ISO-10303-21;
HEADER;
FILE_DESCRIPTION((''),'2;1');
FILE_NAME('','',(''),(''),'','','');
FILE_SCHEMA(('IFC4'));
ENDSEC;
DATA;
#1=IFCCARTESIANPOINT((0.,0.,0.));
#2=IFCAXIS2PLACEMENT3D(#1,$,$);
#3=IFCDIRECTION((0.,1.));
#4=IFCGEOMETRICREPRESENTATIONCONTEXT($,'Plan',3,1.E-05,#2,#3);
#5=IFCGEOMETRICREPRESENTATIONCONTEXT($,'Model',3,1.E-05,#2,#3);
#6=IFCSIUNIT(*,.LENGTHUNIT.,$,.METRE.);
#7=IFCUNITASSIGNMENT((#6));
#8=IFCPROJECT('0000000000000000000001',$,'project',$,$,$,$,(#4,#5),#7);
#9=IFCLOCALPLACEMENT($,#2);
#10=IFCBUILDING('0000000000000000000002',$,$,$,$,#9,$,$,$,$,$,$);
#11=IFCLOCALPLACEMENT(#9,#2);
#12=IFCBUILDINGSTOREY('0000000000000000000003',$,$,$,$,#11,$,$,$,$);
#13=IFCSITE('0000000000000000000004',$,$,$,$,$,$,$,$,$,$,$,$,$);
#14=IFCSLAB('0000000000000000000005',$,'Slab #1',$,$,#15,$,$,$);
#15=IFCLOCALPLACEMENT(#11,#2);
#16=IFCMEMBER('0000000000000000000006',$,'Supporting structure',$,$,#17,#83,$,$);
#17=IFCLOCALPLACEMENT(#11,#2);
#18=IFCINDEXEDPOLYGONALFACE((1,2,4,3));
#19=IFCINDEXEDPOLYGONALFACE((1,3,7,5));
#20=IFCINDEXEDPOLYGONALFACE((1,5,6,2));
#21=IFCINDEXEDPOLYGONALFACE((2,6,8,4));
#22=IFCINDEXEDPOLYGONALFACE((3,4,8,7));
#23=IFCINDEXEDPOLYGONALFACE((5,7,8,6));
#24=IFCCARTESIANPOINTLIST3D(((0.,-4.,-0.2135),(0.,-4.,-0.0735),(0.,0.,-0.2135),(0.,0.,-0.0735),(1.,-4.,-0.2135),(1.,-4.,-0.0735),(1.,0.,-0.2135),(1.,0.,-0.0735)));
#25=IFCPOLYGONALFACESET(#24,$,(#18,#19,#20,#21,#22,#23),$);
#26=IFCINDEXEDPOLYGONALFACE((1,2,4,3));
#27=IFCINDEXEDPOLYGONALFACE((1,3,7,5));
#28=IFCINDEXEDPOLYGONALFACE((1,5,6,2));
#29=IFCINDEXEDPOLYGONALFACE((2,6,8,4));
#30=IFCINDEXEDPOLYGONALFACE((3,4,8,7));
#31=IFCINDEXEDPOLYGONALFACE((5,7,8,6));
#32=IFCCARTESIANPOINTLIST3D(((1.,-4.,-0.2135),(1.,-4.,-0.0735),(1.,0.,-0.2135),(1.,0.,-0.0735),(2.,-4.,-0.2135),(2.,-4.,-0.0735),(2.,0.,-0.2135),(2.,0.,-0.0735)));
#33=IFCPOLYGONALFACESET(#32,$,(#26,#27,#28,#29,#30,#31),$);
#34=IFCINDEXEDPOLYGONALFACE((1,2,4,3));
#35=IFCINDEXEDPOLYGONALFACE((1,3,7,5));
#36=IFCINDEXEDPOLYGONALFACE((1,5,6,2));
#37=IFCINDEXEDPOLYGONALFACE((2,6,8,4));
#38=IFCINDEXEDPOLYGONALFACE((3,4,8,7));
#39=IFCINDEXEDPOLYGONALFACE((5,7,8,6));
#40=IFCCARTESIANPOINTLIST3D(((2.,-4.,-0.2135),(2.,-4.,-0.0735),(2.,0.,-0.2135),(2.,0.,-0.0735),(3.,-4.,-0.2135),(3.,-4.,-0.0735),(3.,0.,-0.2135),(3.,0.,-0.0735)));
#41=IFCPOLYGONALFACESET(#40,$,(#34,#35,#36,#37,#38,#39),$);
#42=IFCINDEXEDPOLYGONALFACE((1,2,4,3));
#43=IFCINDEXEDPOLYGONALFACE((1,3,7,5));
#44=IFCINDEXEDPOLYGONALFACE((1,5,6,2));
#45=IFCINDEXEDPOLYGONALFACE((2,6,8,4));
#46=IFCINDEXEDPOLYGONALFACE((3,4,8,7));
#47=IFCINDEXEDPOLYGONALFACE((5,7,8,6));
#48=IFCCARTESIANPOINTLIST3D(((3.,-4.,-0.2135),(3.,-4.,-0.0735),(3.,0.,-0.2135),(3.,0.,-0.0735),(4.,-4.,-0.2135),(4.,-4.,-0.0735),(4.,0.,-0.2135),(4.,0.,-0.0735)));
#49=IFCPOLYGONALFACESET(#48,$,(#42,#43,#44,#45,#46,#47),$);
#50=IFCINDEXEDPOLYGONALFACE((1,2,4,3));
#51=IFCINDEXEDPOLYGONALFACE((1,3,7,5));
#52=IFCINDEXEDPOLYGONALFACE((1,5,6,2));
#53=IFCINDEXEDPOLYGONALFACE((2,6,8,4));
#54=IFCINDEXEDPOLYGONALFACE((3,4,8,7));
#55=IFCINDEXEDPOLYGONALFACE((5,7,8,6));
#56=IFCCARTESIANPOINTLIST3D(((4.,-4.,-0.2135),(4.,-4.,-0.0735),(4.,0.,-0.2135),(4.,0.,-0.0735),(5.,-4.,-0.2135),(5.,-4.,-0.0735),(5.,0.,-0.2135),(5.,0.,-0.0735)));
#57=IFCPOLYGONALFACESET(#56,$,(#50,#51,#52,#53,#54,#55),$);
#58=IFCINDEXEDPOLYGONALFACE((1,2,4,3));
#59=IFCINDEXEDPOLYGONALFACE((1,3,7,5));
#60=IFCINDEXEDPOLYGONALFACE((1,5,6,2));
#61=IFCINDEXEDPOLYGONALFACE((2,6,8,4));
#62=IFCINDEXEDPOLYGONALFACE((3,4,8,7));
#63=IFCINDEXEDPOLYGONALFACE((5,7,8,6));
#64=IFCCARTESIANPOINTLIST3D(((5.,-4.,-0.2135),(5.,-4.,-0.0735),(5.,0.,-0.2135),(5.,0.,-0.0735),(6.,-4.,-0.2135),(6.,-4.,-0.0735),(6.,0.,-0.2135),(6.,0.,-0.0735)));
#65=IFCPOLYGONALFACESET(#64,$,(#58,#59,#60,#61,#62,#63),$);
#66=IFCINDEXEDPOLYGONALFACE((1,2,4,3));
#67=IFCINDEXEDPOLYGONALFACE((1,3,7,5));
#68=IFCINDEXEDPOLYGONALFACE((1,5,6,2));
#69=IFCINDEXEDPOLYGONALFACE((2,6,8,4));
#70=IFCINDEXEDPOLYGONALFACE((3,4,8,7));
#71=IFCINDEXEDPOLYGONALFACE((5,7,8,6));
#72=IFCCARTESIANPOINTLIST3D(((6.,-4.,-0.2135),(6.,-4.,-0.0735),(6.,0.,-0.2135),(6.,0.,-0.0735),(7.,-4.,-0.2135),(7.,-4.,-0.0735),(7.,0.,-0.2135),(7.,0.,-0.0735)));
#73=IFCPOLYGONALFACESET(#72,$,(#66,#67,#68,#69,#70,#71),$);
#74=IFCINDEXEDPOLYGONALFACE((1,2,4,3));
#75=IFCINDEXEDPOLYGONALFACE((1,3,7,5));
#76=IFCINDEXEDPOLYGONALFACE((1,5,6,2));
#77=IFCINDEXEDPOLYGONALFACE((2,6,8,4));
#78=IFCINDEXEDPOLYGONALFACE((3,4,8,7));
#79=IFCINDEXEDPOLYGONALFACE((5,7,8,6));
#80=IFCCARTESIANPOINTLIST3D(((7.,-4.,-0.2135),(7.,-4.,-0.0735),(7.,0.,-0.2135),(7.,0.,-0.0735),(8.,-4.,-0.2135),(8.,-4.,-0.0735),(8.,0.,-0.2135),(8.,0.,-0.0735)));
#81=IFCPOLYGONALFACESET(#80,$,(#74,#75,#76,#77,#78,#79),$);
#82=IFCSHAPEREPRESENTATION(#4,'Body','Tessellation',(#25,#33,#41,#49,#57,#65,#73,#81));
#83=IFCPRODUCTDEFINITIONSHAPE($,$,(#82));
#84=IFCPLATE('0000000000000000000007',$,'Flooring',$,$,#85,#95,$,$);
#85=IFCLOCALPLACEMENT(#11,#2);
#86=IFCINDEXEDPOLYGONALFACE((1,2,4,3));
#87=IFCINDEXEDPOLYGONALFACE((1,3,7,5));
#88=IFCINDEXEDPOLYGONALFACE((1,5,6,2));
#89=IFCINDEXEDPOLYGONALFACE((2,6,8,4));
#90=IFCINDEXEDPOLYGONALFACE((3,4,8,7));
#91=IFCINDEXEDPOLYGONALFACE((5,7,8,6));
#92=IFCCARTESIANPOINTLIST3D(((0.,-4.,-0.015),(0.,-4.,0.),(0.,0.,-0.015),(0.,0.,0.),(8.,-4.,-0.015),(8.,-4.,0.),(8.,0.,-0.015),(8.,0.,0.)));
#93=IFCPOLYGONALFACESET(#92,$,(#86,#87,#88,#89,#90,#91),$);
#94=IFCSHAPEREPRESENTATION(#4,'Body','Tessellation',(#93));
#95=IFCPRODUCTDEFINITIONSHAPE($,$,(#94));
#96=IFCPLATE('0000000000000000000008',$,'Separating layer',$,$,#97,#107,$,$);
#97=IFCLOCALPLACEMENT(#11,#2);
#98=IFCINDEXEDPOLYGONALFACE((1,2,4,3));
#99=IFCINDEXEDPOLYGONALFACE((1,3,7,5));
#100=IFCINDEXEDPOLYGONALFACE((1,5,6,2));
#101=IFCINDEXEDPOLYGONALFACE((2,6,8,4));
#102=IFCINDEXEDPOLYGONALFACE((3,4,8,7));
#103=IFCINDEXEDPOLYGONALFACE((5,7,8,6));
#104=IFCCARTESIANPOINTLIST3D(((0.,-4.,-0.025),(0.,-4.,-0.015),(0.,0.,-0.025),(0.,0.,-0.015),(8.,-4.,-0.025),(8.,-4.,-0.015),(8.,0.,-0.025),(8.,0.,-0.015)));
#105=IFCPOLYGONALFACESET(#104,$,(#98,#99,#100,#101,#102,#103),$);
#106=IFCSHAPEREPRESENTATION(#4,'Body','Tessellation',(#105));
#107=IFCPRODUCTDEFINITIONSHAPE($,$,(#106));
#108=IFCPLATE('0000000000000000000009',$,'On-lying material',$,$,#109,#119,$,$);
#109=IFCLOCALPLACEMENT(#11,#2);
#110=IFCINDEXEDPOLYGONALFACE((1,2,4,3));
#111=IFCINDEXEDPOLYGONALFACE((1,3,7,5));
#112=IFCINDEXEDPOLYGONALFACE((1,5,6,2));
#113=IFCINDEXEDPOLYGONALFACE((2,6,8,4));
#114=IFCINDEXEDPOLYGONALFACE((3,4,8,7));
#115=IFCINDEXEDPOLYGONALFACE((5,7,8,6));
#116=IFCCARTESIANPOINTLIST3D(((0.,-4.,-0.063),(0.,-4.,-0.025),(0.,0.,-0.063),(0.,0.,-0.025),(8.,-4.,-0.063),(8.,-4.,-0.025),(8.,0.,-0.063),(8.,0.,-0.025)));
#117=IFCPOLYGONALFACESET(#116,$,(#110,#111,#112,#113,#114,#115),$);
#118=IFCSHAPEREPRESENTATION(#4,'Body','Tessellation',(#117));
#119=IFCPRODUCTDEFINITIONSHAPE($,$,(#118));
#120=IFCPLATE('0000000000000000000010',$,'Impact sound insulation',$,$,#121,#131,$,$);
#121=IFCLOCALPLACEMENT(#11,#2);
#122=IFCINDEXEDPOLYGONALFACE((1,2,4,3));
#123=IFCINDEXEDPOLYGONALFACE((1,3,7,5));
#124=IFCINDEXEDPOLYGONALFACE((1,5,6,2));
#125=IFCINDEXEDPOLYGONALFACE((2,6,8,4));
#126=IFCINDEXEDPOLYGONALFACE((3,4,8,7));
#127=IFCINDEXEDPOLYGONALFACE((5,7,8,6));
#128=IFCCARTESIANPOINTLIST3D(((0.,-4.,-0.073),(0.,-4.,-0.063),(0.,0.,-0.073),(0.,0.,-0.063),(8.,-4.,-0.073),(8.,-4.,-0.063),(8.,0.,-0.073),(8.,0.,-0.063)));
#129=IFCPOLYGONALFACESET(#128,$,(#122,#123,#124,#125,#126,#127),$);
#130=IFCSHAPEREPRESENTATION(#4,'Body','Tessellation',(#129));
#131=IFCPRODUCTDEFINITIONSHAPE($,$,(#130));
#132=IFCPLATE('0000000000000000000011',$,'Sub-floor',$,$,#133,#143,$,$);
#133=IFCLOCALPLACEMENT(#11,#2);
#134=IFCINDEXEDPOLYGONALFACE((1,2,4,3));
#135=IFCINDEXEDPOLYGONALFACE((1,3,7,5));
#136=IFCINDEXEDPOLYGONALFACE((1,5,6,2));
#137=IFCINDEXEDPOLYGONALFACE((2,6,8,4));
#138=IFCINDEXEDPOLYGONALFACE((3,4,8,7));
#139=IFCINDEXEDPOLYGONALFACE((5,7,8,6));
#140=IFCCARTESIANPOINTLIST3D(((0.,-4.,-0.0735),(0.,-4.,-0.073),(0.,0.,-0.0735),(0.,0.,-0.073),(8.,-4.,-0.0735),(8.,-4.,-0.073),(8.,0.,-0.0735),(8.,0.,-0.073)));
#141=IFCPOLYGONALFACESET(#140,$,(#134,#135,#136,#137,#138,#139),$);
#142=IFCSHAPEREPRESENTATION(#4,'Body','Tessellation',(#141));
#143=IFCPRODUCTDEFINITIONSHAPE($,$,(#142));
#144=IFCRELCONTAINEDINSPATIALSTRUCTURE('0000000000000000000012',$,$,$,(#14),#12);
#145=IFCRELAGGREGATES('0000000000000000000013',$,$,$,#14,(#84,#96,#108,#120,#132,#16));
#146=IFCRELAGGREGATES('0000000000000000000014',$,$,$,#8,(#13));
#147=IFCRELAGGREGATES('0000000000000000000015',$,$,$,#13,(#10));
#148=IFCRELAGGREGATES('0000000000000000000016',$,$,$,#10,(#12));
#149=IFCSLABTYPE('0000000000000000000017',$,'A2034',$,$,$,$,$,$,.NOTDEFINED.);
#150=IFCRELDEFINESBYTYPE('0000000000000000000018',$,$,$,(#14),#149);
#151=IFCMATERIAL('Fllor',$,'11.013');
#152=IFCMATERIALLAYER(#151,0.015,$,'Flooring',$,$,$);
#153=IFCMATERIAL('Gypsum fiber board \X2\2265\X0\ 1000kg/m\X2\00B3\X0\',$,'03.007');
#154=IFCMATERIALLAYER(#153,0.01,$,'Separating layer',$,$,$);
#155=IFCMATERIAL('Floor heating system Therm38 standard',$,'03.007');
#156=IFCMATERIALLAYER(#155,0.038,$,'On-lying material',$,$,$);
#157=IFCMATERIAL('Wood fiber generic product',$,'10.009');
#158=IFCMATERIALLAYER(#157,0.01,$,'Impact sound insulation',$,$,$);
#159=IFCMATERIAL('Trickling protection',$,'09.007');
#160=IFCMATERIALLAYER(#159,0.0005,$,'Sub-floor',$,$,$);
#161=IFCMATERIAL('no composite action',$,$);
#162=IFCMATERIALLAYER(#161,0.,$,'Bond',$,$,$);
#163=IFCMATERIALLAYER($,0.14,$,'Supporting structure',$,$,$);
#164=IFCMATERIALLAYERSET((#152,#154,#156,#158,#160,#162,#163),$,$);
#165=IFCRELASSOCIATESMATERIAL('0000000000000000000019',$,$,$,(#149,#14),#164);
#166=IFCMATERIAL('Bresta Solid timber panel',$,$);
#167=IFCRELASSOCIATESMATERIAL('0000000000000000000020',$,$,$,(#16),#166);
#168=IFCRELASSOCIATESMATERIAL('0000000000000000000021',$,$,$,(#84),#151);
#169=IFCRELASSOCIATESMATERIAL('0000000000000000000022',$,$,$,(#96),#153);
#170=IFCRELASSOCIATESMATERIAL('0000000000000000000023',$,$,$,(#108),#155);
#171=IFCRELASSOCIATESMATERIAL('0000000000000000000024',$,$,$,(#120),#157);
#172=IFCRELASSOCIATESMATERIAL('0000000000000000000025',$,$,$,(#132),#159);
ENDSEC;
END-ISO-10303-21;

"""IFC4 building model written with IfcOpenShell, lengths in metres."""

from ifc_helpers import new_model, si_unit, direction, frame, frame_2d, origin, origin_with_axes, place, context, project, spatial, rectangle, extrude, material, layer, layer_set, type_object, element, aggregate, save


model = new_model("IFC4")

# Units and contexts
plan_context = context("Plan", 3, precision=1e-05, world=origin(), true_north=direction((0.0, 1.0)))
model_context = context("Model", 3, precision=1e-05, world=origin(), true_north=direction((0.0, 1.0)))
ifc_project = project(units=[si_unit("LENGTHUNIT", "METRE")], contexts=[plan_context, model_context])

# Site, building, storey
site = spatial("IfcSite", under=ifc_project)
building_placement = place(None, origin())
building = spatial("IfcBuilding", under=site, at=building_placement)
storey_placement = place(building_placement, origin())
storey = spatial("IfcBuildingStorey", under=building, at=storey_placement)

# Slab, member, plates
ifc_material_1 = material(Name="Fllor", Category="11.013")
ifc_layer_1 = layer(ifc_material_1, 0.015, Name="Flooring")
ifc_material_2 = material(Name="Gypsum fiber board ≥ 1000kg/m³", Category="03.007")
ifc_layer_2 = layer(ifc_material_2, 0.01, Name="Separating layer")
ifc_material_3 = material(Name="Floor heating system Therm38 standard", Category="03.007")
ifc_layer_3 = layer(ifc_material_3, 0.038, Name="On-lying material")
ifc_material_4 = material(Name="Wood fiber generic product", Category="10.009")
ifc_layer_4 = layer(ifc_material_4, 0.01, Name="Impact sound insulation")
ifc_material_5 = material(Name="Trickling protection", Category="09.007")
ifc_layer_5 = layer(ifc_material_5, 0.0005, Name="Sub-floor")
ifc_material_6 = material(Name="no composite action")
ifc_layer_6 = layer(ifc_material_6, 0.0, Name="Bond")
ifc_layer_7 = layer(None, 0.14, Name="Supporting structure")
ifc_layer_set = layer_set([ifc_layer_1, ifc_layer_2, ifc_layer_3, ifc_layer_4, ifc_layer_5, ifc_layer_6, ifc_layer_7])
slab_type = type_object("IfcSlabType", Name="A2034", PredefinedType="NOTDEFINED", material=ifc_layer_set)
slab_placement = place(None, frame((0.0, 0.0, 0.0), z_axis=(0.0, 0.0, -1.0), x_axis=(1.0, 0.0, 0.0)))
slab = element("IfcSlab", 1, at=slab_placement, inside=storey, type_object=slab_type, material=ifc_layer_set, Name="Slab #1")
ifc_material_7 = material(Name="Bresta Solid timber panel")
member_placement = place(slab_placement, origin())
member = element("IfcMember", 2, at=member_placement, material=ifc_material_7, Name="Supporting structure", context=plan_context, shape_type="SweptSolid", body=[
    extrude(rectangle(XDim=1.0, YDim=0.14, at=frame_2d((0.5, 0.07), x_axis=(1.0, 0.0))), frame((0.0, 4.0, 0.0735), z_axis=(0.0, -1.0, 0.0), x_axis=(1.0, 0.0, 0.0)), (0.0, 0.0, 1.0), 4.0),
    extrude(rectangle(XDim=1.0, YDim=0.14, at=frame_2d((0.5, 0.07), x_axis=(1.0, 0.0))), frame((1.0, 4.0, 0.0735), z_axis=(0.0, -1.0, 0.0), x_axis=(1.0, 0.0, 0.0)), (0.0, 0.0, 1.0), 4.0),
    extrude(rectangle(XDim=1.0, YDim=0.14, at=frame_2d((0.5, 0.07), x_axis=(1.0, 0.0))), frame((2.0, 4.0, 0.0735), z_axis=(0.0, -1.0, 0.0), x_axis=(1.0, 0.0, 0.0)), (0.0, 0.0, 1.0), 4.0),
    extrude(rectangle(XDim=1.0, YDim=0.14, at=frame_2d((0.5, 0.07), x_axis=(1.0, 0.0))), frame((3.0, 4.0, 0.0735), z_axis=(0.0, -1.0, 0.0), x_axis=(1.0, 0.0, 0.0)), (0.0, 0.0, 1.0), 4.0),
    extrude(rectangle(XDim=1.0, YDim=0.14, at=frame_2d((0.5, 0.07), x_axis=(1.0, 0.0))), frame((4.0, 4.0, 0.0735), z_axis=(0.0, -1.0, 0.0), x_axis=(1.0, 0.0, 0.0)), (0.0, 0.0, 1.0), 4.0),
    extrude(rectangle(XDim=1.0, YDim=0.14, at=frame_2d((0.5, 0.07), x_axis=(1.0, 0.0))), frame((5.0, 4.0, 0.0735), z_axis=(0.0, -1.0, 0.0), x_axis=(1.0, 0.0, 0.0)), (0.0, 0.0, 1.0), 4.0),
    extrude(rectangle(XDim=1.0, YDim=0.14, at=frame_2d((0.5, 0.07), x_axis=(1.0, 0.0))), frame((6.0, 4.0, 0.0735), z_axis=(0.0, -1.0, 0.0), x_axis=(1.0, 0.0, 0.0)), (0.0, 0.0, 1.0), 4.0),
    extrude(rectangle(XDim=1.0, YDim=0.14, at=frame_2d((0.5, 0.07), x_axis=(1.0, 0.0))), frame((7.0, 4.0, 0.0735), z_axis=(0.0, -1.0, 0.0), x_axis=(1.0, 0.0, 0.0)), (0.0, 0.0, 1.0), 4.0),
])
plate_1_placement = place(slab_placement, origin())
plate_1 = element("IfcPlate", 3, at=plate_1_placement, material=ifc_material_1, Name="Flooring", context=plan_context, shape_type="SweptSolid", body=[
    extrude(rectangle(XDim=8.0, YDim=4.0, at=frame_2d((4.0, 2.0), x_axis=(1.0, 0.0))), origin_with_axes(), (0.0, 0.0, 1.0), 0.015),
])
plate_2_placement = place(slab_placement, origin())
plate_2 = element("IfcPlate", 4, at=plate_2_placement, material=ifc_material_2, Name="Separating layer", context=plan_context, shape_type="SweptSolid", body=[
    extrude(rectangle(XDim=8.0, YDim=4.0, at=frame_2d((4.0, 2.0), x_axis=(1.0, 0.0))), frame((0.0, 0.0, 0.015), z_axis=(0.0, 0.0, 1.0), x_axis=(1.0, 0.0, 0.0)), (0.0, 0.0, 1.0), 0.01),
])
plate_3_placement = place(slab_placement, origin())
plate_3 = element("IfcPlate", 5, at=plate_3_placement, material=ifc_material_3, Name="On-lying material", context=plan_context, shape_type="SweptSolid", body=[
    extrude(rectangle(XDim=8.0, YDim=4.0, at=frame_2d((4.0, 2.0), x_axis=(1.0, 0.0))), frame((0.0, 0.0, 0.025), z_axis=(0.0, 0.0, 1.0), x_axis=(1.0, 0.0, 0.0)), (0.0, 0.0, 1.0), 0.038),
])
plate_4_placement = place(slab_placement, origin())
plate_4 = element("IfcPlate", 6, at=plate_4_placement, material=ifc_material_4, Name="Impact sound insulation", context=plan_context, shape_type="SweptSolid", body=[
    extrude(rectangle(XDim=8.0, YDim=4.0, at=frame_2d((4.0, 2.0), x_axis=(1.0, 0.0))), frame((0.0, 0.0, 0.063), z_axis=(0.0, 0.0, 1.0), x_axis=(1.0, 0.0, 0.0)), (0.0, 0.0, 1.0), 0.01),
])
plate_5_placement = place(slab_placement, origin())
plate_5 = element("IfcPlate", 7, at=plate_5_placement, material=ifc_material_5, Name="Sub-floor", context=plan_context, shape_type="SweptSolid", body=[
    extrude(rectangle(XDim=8.0, YDim=4.0, at=frame_2d((4.0, 2.0), x_axis=(1.0, 0.0))), frame((0.0, 0.0, 0.073), z_axis=(0.0, 0.0, 1.0), x_axis=(1.0, 0.0, 0.0)), (0.0, 0.0, 1.0), 0.0005),
])
aggregate(slab, [plate_1, plate_2, plate_3, plate_4, plate_5, member])

save(model, "model.ifc")
